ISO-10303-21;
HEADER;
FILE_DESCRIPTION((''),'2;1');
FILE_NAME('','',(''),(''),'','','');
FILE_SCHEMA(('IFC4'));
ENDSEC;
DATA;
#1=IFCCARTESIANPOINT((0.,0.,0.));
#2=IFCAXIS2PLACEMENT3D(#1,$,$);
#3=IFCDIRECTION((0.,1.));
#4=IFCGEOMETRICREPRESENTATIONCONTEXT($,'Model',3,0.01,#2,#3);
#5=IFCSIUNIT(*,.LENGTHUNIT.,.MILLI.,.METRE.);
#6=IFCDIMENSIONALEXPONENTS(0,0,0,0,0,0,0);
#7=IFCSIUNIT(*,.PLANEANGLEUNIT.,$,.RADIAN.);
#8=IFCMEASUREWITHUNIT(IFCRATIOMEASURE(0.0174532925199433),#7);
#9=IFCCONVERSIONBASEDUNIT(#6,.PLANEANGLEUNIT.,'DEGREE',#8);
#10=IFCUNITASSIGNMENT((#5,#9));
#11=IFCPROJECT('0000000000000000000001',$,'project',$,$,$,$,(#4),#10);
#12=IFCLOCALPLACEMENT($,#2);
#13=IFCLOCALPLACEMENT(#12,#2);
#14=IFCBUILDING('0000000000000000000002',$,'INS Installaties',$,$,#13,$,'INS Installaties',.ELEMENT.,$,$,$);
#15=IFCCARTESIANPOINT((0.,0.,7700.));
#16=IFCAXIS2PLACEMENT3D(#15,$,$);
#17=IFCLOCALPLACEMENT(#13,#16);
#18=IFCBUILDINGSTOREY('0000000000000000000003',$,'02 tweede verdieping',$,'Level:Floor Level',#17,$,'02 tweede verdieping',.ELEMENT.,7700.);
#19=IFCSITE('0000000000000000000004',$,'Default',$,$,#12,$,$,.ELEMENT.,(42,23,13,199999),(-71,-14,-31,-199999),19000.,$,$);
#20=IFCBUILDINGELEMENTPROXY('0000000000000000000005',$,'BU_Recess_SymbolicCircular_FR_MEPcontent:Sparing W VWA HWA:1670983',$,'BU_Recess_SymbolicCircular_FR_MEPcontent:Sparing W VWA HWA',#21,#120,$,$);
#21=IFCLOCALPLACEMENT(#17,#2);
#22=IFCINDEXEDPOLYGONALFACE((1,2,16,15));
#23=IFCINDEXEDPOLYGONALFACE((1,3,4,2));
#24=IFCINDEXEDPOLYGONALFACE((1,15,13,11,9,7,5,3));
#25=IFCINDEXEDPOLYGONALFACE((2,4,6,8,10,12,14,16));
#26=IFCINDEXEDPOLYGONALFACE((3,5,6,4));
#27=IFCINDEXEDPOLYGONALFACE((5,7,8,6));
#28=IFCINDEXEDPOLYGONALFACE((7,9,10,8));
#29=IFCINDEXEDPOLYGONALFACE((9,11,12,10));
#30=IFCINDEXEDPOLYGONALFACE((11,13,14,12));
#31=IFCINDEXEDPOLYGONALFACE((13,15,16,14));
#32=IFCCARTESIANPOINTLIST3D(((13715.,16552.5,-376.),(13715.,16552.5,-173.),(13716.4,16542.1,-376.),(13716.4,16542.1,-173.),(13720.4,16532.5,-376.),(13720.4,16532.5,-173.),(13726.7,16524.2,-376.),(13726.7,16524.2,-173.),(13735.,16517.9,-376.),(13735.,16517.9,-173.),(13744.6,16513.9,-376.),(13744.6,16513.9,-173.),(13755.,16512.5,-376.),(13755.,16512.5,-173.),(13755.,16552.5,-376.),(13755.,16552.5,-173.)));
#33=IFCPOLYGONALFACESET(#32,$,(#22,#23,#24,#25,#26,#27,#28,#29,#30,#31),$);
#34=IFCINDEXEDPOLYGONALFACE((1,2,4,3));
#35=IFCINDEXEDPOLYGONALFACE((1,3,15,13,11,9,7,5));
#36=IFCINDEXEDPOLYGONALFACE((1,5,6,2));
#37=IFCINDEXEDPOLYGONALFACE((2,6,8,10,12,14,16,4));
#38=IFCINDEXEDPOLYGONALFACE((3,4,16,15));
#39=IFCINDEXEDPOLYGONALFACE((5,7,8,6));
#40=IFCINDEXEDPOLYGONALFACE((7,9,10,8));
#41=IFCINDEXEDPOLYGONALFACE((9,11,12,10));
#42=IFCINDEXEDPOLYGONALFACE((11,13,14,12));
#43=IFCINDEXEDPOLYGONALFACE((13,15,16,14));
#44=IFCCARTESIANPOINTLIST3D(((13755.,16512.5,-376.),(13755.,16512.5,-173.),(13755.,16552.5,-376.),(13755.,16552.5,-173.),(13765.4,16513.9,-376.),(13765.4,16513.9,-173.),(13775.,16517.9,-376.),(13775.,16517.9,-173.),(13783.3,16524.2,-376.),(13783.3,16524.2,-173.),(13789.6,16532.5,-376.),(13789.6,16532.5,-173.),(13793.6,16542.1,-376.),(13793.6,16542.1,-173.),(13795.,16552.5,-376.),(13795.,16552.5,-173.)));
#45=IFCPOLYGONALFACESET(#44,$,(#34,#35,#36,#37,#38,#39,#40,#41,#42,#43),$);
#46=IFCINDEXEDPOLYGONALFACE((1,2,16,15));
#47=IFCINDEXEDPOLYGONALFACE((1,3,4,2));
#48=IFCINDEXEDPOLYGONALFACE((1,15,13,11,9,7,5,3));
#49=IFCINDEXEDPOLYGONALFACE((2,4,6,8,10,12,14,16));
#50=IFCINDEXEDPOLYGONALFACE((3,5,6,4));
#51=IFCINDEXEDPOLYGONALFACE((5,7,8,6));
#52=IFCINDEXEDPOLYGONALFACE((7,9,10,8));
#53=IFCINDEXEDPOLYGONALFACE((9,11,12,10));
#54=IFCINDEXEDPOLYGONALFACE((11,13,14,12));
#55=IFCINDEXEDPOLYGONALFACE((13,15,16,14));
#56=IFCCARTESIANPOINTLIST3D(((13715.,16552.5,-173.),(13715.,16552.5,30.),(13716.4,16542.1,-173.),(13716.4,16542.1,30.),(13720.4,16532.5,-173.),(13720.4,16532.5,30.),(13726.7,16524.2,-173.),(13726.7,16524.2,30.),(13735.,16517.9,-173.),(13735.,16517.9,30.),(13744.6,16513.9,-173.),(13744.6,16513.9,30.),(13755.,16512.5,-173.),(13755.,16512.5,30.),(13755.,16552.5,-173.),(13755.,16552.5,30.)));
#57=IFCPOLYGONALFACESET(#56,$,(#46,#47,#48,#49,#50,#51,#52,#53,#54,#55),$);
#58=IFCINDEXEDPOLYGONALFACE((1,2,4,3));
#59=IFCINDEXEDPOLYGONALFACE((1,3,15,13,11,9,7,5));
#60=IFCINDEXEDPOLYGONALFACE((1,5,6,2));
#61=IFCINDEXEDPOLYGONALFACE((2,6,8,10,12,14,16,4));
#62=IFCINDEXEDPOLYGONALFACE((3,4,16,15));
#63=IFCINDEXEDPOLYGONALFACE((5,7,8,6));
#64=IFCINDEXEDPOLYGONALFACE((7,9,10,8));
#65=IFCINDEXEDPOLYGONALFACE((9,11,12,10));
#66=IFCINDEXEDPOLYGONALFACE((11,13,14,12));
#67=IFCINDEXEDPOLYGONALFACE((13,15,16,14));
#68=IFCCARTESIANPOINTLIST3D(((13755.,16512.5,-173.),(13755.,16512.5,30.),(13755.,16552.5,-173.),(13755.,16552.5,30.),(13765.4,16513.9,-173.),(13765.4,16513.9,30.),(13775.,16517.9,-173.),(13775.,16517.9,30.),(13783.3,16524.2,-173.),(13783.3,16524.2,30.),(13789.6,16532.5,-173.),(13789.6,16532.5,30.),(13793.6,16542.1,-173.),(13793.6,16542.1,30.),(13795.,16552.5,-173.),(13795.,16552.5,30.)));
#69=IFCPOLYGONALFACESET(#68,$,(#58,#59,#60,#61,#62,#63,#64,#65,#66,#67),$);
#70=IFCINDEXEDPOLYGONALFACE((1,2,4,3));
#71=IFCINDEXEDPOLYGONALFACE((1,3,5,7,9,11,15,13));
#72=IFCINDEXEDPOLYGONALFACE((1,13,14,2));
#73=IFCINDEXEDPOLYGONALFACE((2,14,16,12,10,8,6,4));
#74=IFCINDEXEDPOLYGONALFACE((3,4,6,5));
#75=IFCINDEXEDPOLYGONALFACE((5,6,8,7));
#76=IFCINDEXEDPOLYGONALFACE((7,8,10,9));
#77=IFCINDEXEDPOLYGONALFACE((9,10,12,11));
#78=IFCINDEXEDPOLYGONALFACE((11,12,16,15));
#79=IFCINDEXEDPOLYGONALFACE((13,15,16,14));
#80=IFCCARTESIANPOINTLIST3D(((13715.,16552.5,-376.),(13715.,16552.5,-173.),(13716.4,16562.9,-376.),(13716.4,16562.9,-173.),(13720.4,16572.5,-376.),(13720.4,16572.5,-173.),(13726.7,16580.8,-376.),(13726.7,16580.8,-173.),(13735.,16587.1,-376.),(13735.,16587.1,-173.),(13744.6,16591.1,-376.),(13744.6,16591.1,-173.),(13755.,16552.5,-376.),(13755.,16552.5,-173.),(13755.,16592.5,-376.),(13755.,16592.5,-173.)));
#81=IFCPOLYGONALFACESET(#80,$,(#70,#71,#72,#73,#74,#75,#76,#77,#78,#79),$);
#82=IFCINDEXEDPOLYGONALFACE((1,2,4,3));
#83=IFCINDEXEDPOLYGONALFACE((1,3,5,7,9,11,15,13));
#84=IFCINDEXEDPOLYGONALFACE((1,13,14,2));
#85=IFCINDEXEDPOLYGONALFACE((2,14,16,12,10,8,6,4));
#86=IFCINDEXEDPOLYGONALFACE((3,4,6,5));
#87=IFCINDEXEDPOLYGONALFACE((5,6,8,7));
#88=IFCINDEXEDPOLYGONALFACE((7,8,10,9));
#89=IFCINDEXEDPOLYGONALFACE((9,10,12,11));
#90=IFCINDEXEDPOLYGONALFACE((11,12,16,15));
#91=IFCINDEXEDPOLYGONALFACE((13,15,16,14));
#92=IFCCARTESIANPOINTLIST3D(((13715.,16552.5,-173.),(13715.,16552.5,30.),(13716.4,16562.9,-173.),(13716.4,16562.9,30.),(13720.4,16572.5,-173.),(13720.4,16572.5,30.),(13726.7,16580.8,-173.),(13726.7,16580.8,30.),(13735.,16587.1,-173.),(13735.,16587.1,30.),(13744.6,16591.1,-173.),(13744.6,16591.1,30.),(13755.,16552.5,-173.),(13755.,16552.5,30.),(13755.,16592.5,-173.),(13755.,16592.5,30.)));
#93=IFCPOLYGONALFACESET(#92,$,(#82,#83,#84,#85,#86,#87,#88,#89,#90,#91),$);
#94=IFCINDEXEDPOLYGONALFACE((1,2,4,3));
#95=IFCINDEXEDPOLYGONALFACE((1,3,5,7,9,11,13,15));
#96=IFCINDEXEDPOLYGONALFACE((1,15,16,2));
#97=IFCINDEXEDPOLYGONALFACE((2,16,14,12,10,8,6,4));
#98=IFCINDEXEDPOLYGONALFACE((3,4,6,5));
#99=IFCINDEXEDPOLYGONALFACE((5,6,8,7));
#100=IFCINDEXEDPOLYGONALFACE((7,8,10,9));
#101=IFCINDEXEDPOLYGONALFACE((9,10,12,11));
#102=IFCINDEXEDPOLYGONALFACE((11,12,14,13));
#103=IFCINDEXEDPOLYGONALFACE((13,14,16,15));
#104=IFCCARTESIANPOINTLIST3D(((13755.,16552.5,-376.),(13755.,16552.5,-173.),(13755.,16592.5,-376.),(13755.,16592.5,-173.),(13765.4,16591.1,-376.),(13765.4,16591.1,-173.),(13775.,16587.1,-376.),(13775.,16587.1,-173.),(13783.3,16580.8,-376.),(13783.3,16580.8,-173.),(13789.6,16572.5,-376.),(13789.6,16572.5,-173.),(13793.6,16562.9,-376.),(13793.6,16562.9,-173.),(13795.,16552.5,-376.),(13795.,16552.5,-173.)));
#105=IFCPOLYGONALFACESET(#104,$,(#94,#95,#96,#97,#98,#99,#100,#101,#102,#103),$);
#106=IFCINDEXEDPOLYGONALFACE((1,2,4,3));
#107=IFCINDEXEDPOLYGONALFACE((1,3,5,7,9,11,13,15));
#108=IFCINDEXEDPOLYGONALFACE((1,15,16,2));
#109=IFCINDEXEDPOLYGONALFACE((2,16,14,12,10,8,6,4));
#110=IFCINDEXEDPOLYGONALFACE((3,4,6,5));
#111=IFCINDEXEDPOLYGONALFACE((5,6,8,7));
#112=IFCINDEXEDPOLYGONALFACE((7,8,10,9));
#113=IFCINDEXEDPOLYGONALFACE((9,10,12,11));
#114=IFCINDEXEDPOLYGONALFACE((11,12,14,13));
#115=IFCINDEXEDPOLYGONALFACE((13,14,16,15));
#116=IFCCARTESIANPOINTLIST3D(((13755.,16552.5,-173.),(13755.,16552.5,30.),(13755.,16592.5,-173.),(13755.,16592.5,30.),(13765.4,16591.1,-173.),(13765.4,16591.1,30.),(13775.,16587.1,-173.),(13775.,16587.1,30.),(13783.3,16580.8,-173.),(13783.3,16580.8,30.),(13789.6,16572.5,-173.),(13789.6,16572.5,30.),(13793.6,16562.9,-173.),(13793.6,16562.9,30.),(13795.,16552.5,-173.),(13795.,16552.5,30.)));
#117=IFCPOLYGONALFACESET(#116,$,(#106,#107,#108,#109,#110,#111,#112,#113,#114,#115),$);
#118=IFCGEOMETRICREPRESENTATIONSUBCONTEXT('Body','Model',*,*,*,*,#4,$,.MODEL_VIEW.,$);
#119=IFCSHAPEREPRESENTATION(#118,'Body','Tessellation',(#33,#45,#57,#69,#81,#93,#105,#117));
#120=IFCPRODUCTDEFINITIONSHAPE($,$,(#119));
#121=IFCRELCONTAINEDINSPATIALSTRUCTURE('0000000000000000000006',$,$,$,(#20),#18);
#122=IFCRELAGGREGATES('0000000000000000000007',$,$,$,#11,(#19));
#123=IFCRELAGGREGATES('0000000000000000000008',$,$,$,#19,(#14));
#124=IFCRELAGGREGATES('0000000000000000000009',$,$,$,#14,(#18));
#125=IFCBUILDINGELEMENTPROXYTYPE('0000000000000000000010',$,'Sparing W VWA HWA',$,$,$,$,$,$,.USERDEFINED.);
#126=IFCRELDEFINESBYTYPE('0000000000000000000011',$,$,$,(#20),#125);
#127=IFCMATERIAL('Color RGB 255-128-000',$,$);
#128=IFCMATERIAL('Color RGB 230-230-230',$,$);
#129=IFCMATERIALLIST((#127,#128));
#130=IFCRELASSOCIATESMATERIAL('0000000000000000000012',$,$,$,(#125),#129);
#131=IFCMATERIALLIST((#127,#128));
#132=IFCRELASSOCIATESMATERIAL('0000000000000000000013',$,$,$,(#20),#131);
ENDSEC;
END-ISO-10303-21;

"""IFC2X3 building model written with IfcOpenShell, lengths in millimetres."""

from ifc_helpers import new_model, entity, si_unit, converted_unit, direction, frame, frame_2d, origin, place, context, subcontext, project, spatial, polyline, circle_curve, parameter, trimmed, segment, composite_curve, outline, extrude, source, transform, mapped, material, material_list, type_object, type_shapes, element, save


model = new_model("IFC2X3")

# Units and contexts
model_context = context("Model", 3, precision=0.01, world=origin(), true_north=direction((0.0, 1.0)))
body_context = subcontext(model_context, "Body", "Model", "MODEL_VIEW")
ifc_project = project(units=[si_unit("LENGTHUNIT", "METRE", prefix="MILLI"), converted_unit("PLANEANGLEUNIT", "DEGREE", entity("IfcRatioMeasure", 0.0174532925199433), si_unit("PLANEANGLEUNIT", "RADIAN"), dimensions=[0, 0, 0, 0, 0, 0, 0])], contexts=[model_context])

# Site, building, storey
site_placement = place(None, origin())
site = spatial("IfcSite", under=ifc_project, at=site_placement, Name="Default", CompositionType="ELEMENT", RefLatitude=(42, 23, 13, 199999), RefLongitude=(-71, -14, -31, -199999), RefElevation=19000.0)
building_placement = place(site_placement, origin())
building = spatial("IfcBuilding", under=site, at=building_placement, Name="INS Installaties", LongName="INS Installaties", CompositionType="ELEMENT")
storey_placement = place(building_placement, frame((0.0, 0.0, 7700.0)))
storey = spatial("IfcBuildingStorey", under=building, at=storey_placement, Name="02 tweede verdieping", ObjectType="Level:Floor Level", LongName="02 tweede verdieping", CompositionType="ELEMENT", Elevation=7700.0)

# Building element proxy
ifc_material_1 = material(Name="Color RGB 255-128-000")
ifc_material_2 = material(Name="Color RGB 230-230-230")
ifc_material_list_1 = material_list([ifc_material_1, ifc_material_2])
building_element_proxy_type_1 = type_object("IfcBuildingElementProxyType", Name="Sparing W VWA HWA", PredefinedType="USERDEFINED", material=ifc_material_list_1)
shared_shape_1 = source(origin(), body_context, "Body", "SweptSolid", [
    extrude(outline(composite_curve([segment(trimmed(circle_curve(frame_2d((13.3, 13.3), x_axis=(1.0, 0.0)), 40.0), [parameter(180.0)], [parameter(270.0)], True, "PARAMETER"), True, "CONTINUOUS"), segment(polyline([(13.3, -26.7), (13.3, 13.3)]), True, "CONTINUOUS"), segment(polyline([(13.3, 13.3), (-26.7, 13.3)]), True, "CONTINUOUS")], self_intersect=False)), frame((13.3, 13.3, -403.0), z_axis=(0.0, 0.0, 1.0), x_axis=(-1.0, 0.0, 0.0)), (0.0, 0.0, 1.0), 203.0),
    extrude(outline(composite_curve([segment(polyline([(-26.7, -13.3), (13.3, -13.3)]), True, "CONTINUOUS"), segment(polyline([(13.3, -13.3), (13.3, 26.7)]), True, "CONTINUOUS"), segment(trimmed(circle_curve(frame_2d((13.3, -13.3), x_axis=(1.0, 0.0)), 40.0), [parameter(90.0)], [parameter(180.0)], True, "PARAMETER"), True, "CONTINUOUS")], self_intersect=False)), frame((-13.3, 13.3, -403.0)), (0.0, 0.0, 1.0), 203.0),
    extrude(outline(composite_curve([segment(trimmed(circle_curve(frame_2d((13.3, 13.3), x_axis=(1.0, 0.0)), 40.0), [parameter(180.0)], [parameter(270.0)], True, "PARAMETER"), True, "CONTINUOUS"), segment(polyline([(13.3, -26.7), (13.3, 13.3)]), True, "CONTINUOUS"), segment(polyline([(13.3, 13.3), (-26.7, 13.3)]), True, "CONTINUOUS")], self_intersect=False)), frame((13.3, 13.3, -200.0), z_axis=(0.0, 0.0, 1.0), x_axis=(-1.0, 0.0, 0.0)), (0.0, 0.0, 1.0), 203.0),
    extrude(outline(composite_curve([segment(polyline([(-26.7, -13.3), (13.3, -13.3)]), True, "CONTINUOUS"), segment(polyline([(13.3, -13.3), (13.3, 26.7)]), True, "CONTINUOUS"), segment(trimmed(circle_curve(frame_2d((13.3, -13.3), x_axis=(1.0, 0.0)), 40.0), [parameter(90.0)], [parameter(180.0)], True, "PARAMETER"), True, "CONTINUOUS")], self_intersect=False)), frame((-13.3, 13.3, -200.0)), (0.0, 0.0, 1.0), 203.0),
    extrude(outline(composite_curve([segment(polyline([(-26.7, -13.3), (13.3, -13.3)]), True, "CONTINUOUS"), segment(polyline([(13.3, -13.3), (13.3, 26.7)]), True, "CONTINUOUS"), segment(trimmed(circle_curve(frame_2d((13.3, -13.3), x_axis=(1.0, 0.0)), 40.0), [parameter(90.0)], [parameter(180.0)], True, "PARAMETER"), True, "CONTINUOUS")], self_intersect=False)), frame((13.3, -13.3, -403.0), z_axis=(0.0, 0.0, 1.0), x_axis=(-1.0, 0.0, 0.0)), (0.0, 0.0, 1.0), 203.0),
    extrude(outline(composite_curve([segment(polyline([(-26.7, -13.3), (13.3, -13.3)]), True, "CONTINUOUS"), segment(polyline([(13.3, -13.3), (13.3, 26.7)]), True, "CONTINUOUS"), segment(trimmed(circle_curve(frame_2d((13.3, -13.3), x_axis=(1.0, 0.0)), 40.0), [parameter(90.0)], [parameter(180.0)], True, "PARAMETER"), True, "CONTINUOUS")], self_intersect=False)), frame((13.3, -13.3, -200.0), z_axis=(0.0, 0.0, 1.0), x_axis=(-1.0, 0.0, 0.0)), (0.0, 0.0, 1.0), 203.0),
    extrude(outline(composite_curve([segment(trimmed(circle_curve(frame_2d((13.3, 13.3), x_axis=(1.0, 0.0)), 40.0), [parameter(180.0)], [parameter(270.0)], True, "PARAMETER"), True, "CONTINUOUS"), segment(polyline([(13.3, -26.7), (13.3, 13.3)]), True, "CONTINUOUS"), segment(polyline([(13.3, 13.3), (-26.7, 13.3)]), True, "CONTINUOUS")], self_intersect=False)), frame((-13.3, -13.3, -403.0)), (0.0, 0.0, 1.0), 203.0),
    extrude(outline(composite_curve([segment(trimmed(circle_curve(frame_2d((13.3, 13.3), x_axis=(1.0, 0.0)), 40.0), [parameter(180.0)], [parameter(270.0)], True, "PARAMETER"), True, "CONTINUOUS"), segment(polyline([(13.3, -26.7), (13.3, 13.3)]), True, "CONTINUOUS"), segment(polyline([(13.3, 13.3), (-26.7, 13.3)]), True, "CONTINUOUS")], self_intersect=False)), frame((-13.3, -13.3, -200.0)), (0.0, 0.0, 1.0), 203.0),
])
type_shapes(building_element_proxy_type_1, [shared_shape_1])
ifc_material_list_2 = material_list([ifc_material_1, ifc_material_2])
proxy_1_placement = place(storey_placement, frame((13755.0, 16552.5, 27.0), z_axis=(0.0, 0.0, 1.0), x_axis=(-1.0, 0.0, 0.0)))
element("IfcBuildingElementProxy", 1, at=proxy_1_placement, inside=storey, type_object=building_element_proxy_type_1, material=ifc_material_list_2, Name="BU_Recess_SymbolicCircular_FR_MEPcontent:Sparing W VWA HWA:1670983", ObjectType="BU_Recess_SymbolicCircular_FR_MEPcontent:Sparing W VWA HWA", context=body_context, shape_type="MappedRepresentation", body=[
    mapped(shared_shape_1, transform((0.0, 0.0, 0.0), scale=1.0)),
])

save(model, "model.ifc")
